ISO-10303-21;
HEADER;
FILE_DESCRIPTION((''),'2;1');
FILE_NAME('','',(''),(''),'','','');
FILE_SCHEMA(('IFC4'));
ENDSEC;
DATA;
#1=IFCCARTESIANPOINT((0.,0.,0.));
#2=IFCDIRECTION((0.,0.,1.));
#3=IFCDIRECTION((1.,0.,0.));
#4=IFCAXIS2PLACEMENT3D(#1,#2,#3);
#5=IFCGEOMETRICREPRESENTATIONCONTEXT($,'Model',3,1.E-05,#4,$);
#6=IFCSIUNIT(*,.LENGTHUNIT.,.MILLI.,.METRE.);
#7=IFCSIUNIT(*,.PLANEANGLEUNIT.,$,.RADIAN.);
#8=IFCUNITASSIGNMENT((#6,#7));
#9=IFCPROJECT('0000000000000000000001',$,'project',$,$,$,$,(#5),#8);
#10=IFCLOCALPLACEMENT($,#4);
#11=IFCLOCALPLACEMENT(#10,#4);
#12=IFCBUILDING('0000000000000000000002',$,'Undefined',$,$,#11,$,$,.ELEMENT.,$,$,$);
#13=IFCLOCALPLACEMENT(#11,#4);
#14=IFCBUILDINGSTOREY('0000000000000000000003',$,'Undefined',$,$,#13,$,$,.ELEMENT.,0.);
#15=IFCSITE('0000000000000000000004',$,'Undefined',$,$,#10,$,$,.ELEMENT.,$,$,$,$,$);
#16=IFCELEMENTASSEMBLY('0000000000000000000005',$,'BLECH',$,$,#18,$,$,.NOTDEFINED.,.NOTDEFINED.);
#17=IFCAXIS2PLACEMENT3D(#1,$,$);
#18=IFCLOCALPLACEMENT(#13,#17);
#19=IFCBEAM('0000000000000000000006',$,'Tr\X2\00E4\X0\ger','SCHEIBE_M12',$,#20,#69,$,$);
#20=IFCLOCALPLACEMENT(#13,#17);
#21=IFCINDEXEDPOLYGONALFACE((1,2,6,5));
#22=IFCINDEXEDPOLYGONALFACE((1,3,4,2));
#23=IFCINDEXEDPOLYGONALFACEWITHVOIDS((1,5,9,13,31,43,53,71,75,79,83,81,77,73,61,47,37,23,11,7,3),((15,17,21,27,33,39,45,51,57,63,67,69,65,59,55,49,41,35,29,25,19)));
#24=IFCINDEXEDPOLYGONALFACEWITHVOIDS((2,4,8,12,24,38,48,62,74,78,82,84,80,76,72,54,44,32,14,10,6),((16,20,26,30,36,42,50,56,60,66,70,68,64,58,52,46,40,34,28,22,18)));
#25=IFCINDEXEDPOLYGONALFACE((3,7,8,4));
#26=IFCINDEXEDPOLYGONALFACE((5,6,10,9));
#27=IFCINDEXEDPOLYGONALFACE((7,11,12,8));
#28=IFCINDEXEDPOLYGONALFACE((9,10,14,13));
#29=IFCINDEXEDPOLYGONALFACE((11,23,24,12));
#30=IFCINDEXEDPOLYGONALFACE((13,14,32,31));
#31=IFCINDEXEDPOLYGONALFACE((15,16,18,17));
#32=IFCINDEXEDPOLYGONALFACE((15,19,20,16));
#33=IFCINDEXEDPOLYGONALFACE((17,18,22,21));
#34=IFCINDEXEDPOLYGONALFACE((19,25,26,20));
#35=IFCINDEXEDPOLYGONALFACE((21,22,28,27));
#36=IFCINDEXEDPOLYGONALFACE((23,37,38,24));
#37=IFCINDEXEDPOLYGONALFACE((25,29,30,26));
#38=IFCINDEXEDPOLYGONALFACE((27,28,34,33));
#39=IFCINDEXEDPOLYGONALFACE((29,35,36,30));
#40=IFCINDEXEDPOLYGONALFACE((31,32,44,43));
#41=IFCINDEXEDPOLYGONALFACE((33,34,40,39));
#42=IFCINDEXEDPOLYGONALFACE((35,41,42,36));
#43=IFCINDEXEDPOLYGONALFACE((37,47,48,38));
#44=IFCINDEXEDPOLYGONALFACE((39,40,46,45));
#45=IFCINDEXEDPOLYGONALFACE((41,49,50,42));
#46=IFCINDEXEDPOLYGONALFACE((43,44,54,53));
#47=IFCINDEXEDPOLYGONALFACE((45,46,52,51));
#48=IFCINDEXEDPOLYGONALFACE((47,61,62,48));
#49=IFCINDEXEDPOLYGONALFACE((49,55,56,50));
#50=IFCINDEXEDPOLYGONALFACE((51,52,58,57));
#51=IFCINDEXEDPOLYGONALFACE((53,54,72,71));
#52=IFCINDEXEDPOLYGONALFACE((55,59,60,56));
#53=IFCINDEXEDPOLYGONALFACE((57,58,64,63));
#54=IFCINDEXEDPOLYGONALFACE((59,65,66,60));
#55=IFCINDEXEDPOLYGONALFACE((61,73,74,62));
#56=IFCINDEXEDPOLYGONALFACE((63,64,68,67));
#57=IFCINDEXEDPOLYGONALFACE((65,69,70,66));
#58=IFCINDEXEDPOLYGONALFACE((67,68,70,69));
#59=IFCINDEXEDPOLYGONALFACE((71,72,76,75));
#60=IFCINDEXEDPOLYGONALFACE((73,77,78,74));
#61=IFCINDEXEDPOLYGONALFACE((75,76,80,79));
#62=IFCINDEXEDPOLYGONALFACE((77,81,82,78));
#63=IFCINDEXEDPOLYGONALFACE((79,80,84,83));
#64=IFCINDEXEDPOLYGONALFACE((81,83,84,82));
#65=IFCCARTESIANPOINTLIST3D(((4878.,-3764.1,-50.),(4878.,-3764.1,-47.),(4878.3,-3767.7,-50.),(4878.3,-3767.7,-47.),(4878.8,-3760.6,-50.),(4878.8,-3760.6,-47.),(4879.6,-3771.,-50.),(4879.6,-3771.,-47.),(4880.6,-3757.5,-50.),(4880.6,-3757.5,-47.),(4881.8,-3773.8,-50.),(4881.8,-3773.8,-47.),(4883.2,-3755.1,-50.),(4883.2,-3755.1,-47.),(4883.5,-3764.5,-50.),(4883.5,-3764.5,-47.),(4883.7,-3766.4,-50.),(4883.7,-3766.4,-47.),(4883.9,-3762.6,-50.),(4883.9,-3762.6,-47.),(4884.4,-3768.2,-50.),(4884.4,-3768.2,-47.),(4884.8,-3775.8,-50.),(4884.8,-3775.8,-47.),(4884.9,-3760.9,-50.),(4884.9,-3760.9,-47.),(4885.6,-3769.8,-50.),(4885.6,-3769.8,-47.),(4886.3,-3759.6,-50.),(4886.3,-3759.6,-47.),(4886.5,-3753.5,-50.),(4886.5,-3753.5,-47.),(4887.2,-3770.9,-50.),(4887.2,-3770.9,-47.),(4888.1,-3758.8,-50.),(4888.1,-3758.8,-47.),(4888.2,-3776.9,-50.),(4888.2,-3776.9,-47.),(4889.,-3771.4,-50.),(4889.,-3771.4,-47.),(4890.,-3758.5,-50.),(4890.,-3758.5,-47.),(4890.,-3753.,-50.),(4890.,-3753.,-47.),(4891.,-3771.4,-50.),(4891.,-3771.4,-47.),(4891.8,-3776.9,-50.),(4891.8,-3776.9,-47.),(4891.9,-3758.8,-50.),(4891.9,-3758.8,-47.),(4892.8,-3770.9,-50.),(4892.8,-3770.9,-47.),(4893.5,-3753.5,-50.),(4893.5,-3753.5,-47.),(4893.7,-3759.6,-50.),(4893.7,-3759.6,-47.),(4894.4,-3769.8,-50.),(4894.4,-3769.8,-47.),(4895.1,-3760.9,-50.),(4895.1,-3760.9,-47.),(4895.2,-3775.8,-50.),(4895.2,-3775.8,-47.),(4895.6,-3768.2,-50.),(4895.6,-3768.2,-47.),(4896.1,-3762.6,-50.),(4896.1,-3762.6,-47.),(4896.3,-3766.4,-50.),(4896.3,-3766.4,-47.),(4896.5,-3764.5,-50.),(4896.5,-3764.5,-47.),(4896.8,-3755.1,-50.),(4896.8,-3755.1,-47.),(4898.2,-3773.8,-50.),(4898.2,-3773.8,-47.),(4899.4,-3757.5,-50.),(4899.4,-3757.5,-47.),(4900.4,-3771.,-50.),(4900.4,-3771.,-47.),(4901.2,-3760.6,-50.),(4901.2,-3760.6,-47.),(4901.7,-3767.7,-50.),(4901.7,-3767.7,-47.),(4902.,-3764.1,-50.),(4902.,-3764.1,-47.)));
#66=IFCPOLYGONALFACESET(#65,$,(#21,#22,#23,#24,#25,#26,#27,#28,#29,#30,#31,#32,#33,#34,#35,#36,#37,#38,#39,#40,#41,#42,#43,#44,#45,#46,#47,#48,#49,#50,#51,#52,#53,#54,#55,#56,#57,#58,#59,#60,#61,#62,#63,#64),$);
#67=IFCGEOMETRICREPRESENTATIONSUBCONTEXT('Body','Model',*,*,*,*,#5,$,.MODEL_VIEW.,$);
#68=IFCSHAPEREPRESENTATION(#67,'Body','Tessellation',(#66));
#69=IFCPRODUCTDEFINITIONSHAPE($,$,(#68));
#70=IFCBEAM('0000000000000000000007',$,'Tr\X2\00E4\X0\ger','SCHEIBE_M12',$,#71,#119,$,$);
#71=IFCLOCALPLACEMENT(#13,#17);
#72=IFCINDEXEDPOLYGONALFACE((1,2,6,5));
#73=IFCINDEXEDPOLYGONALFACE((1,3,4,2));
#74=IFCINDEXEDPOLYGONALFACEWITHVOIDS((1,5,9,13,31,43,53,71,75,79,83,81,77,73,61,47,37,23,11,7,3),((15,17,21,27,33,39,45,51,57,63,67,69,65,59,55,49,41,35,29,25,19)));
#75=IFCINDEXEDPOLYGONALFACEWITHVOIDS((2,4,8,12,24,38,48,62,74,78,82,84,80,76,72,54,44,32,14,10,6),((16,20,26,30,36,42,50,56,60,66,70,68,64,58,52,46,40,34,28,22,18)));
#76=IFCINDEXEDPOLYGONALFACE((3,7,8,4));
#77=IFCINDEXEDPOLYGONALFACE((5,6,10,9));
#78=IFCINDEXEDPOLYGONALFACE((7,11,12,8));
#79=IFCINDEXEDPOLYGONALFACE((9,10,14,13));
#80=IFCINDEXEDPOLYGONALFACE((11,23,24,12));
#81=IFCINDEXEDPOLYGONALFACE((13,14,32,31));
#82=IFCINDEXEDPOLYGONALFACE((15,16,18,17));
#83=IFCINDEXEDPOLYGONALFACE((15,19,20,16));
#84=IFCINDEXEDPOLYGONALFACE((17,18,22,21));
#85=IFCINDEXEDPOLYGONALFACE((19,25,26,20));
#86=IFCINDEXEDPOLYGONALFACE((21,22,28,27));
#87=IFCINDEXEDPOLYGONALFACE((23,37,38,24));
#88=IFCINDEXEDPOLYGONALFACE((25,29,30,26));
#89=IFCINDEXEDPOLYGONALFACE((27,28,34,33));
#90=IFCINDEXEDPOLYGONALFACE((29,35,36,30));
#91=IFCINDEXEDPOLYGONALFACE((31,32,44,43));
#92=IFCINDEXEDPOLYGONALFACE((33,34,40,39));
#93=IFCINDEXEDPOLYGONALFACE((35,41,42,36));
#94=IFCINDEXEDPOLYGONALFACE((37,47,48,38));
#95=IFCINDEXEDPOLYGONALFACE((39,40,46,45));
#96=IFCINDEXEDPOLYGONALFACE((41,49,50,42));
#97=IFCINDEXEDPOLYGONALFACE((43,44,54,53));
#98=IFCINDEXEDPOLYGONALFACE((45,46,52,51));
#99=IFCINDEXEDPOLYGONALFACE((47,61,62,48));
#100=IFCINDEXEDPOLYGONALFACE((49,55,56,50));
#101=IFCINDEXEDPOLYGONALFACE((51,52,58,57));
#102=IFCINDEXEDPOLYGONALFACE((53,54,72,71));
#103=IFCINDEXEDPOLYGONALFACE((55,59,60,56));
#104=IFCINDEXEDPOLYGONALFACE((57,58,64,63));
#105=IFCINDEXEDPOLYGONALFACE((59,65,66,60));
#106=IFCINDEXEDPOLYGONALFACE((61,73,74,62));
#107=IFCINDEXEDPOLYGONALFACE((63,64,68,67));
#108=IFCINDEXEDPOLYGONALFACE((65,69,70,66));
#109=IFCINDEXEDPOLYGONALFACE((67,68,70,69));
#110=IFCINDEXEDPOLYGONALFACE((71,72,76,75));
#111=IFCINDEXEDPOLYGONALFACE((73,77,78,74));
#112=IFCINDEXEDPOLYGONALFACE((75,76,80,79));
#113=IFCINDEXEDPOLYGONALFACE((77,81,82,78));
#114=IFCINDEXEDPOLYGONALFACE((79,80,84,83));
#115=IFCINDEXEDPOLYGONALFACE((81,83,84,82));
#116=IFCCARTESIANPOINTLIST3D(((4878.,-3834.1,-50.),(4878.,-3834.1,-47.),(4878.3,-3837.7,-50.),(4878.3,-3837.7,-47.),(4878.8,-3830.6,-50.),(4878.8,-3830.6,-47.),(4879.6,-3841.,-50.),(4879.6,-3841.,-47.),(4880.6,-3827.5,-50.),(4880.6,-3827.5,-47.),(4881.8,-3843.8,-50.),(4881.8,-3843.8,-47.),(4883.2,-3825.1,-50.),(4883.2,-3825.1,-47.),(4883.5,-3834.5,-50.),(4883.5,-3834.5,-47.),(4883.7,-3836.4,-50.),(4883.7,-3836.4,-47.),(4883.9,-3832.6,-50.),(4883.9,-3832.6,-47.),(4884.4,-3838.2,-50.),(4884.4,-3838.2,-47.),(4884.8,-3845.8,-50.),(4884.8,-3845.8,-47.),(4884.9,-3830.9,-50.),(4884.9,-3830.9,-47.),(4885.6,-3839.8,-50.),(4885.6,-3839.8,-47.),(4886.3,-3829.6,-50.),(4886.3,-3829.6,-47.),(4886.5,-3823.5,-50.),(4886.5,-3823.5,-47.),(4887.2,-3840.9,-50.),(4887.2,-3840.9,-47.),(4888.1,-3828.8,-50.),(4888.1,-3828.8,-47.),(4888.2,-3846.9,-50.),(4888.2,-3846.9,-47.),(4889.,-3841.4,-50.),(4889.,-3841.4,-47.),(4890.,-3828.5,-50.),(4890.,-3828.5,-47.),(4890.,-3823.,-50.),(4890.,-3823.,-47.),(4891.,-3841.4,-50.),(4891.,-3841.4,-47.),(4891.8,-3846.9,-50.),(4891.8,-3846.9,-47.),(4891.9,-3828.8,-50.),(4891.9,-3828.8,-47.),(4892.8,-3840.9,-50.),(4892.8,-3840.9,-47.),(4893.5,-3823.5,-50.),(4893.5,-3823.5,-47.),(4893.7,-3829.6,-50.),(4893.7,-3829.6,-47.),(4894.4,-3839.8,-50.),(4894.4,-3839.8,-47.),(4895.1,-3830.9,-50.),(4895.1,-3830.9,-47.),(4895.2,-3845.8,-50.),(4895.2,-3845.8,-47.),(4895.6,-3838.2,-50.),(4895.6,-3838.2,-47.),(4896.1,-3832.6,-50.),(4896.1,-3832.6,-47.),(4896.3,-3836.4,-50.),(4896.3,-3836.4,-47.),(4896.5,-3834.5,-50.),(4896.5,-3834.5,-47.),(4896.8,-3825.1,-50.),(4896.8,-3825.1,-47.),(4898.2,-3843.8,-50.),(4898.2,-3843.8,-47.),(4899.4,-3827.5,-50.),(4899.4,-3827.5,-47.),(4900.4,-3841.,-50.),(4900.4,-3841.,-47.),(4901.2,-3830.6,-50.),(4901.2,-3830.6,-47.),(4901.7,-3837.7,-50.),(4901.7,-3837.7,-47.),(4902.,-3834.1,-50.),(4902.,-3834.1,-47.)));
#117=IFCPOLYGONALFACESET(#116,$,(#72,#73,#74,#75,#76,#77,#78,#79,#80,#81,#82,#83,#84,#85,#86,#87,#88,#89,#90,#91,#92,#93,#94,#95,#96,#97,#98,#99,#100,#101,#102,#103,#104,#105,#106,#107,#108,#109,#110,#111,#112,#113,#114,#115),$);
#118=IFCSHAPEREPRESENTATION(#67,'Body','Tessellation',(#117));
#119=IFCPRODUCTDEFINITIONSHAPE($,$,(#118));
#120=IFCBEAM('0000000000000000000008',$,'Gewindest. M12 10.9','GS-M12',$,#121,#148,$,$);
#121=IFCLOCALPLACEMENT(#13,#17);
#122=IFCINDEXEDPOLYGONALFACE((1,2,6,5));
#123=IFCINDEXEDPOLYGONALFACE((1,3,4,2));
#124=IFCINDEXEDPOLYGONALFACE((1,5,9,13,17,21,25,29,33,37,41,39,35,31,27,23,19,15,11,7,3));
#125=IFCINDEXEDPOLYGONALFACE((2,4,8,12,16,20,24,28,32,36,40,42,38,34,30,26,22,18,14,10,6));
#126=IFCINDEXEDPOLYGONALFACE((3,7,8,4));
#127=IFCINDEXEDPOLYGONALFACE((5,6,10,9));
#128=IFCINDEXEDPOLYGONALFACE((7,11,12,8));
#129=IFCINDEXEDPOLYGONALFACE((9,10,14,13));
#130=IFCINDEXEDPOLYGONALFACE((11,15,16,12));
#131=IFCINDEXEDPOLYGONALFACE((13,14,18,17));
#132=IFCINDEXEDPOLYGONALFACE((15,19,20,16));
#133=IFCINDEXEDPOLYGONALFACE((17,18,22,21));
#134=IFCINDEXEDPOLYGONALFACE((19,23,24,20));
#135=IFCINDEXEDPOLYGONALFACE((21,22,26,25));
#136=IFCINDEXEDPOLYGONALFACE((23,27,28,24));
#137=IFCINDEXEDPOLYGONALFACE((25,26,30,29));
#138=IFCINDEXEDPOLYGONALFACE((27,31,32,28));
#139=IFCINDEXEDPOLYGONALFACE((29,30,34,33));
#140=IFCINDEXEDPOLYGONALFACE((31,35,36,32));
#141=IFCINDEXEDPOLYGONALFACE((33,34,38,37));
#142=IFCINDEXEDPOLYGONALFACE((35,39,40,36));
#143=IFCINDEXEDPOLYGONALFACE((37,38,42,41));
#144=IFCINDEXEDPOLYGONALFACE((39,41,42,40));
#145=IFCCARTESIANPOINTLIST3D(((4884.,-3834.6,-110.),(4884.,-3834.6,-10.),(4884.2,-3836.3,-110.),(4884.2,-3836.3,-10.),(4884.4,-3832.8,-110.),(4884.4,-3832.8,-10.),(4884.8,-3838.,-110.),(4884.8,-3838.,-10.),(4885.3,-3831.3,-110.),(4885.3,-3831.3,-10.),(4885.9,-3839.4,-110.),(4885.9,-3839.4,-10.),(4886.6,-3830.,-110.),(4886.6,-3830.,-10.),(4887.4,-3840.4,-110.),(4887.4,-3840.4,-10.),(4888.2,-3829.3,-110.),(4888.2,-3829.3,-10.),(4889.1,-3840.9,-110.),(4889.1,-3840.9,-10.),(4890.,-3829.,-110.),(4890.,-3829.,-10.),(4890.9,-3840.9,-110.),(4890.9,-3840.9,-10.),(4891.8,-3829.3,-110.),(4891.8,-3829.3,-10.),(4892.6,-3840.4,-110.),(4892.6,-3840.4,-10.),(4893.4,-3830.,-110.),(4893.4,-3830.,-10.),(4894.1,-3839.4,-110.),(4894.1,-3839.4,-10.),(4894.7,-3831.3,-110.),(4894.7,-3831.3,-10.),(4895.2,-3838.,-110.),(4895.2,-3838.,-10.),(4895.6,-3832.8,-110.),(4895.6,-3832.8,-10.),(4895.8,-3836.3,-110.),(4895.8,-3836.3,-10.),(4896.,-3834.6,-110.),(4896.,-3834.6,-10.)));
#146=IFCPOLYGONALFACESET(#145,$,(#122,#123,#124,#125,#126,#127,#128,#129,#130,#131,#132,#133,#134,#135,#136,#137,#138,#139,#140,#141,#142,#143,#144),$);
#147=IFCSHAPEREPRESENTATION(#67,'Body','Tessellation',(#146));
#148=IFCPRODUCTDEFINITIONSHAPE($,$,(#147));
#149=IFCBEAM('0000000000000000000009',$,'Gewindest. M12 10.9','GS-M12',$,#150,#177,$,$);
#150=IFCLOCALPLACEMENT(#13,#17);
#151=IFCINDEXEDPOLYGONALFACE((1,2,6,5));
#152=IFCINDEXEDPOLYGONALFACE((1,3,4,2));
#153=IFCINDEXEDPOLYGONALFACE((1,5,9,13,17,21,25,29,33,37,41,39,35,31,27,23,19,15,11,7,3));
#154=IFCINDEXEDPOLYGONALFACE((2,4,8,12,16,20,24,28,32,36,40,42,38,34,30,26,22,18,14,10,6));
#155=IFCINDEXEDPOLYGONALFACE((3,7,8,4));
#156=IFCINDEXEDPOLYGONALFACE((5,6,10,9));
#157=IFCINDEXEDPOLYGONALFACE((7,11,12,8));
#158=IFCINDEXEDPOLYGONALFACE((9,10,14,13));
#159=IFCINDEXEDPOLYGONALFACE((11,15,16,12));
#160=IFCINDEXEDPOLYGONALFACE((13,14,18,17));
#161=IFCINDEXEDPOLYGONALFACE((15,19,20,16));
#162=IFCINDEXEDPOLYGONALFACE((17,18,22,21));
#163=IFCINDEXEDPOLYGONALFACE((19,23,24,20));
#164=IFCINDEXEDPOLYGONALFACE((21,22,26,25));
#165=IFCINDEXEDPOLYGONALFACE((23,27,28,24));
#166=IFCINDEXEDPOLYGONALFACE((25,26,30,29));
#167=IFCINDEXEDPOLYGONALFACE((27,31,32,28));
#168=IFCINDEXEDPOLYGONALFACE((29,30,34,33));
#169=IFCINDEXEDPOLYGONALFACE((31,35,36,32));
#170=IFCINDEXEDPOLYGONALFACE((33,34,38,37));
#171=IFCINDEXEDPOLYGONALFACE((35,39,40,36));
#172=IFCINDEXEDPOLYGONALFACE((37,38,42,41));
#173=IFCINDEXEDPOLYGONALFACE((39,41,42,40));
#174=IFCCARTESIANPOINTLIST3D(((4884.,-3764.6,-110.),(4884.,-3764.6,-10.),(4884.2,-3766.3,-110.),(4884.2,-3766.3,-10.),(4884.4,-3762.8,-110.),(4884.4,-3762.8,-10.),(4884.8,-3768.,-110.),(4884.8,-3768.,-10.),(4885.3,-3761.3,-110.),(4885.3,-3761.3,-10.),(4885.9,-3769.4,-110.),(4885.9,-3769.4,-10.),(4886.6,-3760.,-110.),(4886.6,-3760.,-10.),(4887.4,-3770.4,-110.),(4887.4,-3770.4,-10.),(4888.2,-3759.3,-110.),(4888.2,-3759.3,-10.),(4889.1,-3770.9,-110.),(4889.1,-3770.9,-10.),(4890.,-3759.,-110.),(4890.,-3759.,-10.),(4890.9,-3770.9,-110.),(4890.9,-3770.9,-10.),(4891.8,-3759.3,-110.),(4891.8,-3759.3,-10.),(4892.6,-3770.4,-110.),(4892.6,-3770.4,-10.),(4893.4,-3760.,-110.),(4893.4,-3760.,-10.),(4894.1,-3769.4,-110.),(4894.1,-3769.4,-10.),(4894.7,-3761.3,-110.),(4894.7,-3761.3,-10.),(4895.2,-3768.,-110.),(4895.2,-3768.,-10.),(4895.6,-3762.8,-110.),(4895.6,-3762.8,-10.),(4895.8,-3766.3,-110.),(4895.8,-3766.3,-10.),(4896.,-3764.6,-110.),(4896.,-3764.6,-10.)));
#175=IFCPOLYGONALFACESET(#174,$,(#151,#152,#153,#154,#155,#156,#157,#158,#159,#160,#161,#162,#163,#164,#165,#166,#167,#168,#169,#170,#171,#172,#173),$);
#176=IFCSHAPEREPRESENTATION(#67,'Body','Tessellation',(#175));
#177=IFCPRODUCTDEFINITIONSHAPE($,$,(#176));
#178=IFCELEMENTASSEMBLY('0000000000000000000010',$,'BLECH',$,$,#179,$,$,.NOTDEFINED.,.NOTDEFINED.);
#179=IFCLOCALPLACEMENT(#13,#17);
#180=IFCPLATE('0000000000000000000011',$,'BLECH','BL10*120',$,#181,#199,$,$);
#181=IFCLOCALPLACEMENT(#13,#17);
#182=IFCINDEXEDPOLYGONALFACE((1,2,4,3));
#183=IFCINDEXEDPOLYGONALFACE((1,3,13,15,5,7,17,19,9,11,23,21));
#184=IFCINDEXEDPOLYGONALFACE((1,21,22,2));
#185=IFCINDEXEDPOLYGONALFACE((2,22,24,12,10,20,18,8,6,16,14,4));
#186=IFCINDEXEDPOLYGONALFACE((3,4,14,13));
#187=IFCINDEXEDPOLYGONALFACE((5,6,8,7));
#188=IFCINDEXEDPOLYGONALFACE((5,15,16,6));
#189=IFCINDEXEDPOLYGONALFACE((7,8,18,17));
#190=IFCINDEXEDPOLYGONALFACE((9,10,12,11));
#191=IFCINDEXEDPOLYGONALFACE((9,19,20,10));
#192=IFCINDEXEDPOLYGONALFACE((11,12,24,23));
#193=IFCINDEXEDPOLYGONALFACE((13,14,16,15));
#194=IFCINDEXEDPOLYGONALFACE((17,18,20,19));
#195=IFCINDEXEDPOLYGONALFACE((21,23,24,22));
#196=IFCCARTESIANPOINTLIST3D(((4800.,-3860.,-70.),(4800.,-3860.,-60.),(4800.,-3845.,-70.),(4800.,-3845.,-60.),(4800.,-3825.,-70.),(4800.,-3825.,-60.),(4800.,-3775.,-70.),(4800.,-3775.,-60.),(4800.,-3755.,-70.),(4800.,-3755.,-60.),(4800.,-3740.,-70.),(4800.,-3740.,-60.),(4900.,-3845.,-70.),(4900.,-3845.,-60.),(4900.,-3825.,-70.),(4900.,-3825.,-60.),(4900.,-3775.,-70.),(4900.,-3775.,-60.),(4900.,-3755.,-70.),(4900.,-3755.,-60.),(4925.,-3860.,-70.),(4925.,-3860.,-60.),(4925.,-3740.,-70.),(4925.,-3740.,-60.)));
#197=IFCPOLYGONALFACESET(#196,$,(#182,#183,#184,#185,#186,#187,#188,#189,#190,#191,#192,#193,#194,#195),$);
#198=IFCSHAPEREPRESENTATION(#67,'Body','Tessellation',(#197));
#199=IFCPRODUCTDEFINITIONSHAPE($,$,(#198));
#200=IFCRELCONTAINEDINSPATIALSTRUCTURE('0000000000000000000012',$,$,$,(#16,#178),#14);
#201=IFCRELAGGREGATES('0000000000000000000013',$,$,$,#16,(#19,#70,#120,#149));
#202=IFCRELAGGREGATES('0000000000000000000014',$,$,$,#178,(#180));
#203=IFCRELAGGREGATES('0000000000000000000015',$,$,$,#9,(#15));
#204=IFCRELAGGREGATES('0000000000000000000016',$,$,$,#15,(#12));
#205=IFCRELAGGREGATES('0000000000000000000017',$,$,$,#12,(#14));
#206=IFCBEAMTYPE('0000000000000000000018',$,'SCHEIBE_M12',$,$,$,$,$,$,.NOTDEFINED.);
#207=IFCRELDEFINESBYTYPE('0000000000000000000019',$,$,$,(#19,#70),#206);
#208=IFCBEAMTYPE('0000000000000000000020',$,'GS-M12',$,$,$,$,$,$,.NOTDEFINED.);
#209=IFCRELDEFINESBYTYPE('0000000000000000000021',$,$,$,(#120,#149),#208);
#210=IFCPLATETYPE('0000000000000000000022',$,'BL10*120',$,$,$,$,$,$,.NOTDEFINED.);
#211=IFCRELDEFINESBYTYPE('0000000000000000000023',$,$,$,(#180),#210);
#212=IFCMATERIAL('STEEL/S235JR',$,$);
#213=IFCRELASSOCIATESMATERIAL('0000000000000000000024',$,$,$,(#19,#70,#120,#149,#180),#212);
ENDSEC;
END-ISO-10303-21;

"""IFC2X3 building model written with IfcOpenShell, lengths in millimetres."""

from ifc_helpers import new_model, si_unit, frame, origin_with_axes, origin_2d_with_axis, place, context, subcontext, project, spatial, polyline, circle, hollow_circle, outline, extrude, material, type_object, element, aggregate, save


model = new_model("IFC2X3")

# Units and contexts
model_context = context("Model", 3, precision=1e-05, world=origin_with_axes())
body_context = subcontext(model_context, "Body", "Model", "MODEL_VIEW")
ifc_project = project(units=[si_unit("LENGTHUNIT", "METRE", prefix="MILLI"), si_unit("PLANEANGLEUNIT", "RADIAN")], contexts=[model_context])

# Site, building, storey
site_placement = place(None, origin_with_axes())
site = spatial("IfcSite", under=ifc_project, at=site_placement, Name="Undefined", CompositionType="ELEMENT")
building_placement = place(site_placement, origin_with_axes())
building = spatial("IfcBuilding", under=site, at=building_placement, Name="Undefined", CompositionType="ELEMENT")
storey_placement = place(building_placement, origin_with_axes())
storey = spatial("IfcBuildingStorey", under=building, at=storey_placement, Name="Undefined", CompositionType="ELEMENT", Elevation=0.0)

# Shared definitions
ifc_material_1 = material(Name="STEEL/S235JR")

# Element assembly, beams
assembly_1_placement = place(storey_placement, origin_with_axes())
assembly_1 = element("IfcElementAssembly", 1, at=assembly_1_placement, inside=storey, Name="BLECH", AssemblyPlace="NOTDEFINED", PredefinedType="NOTDEFINED")
beam_type_1 = type_object("IfcBeamType", Name="SCHEIBE_M12", PredefinedType="NOTDEFINED")
beam_1_placement = place(assembly_1_placement, frame((4890.0, -3765.0, -47.0), z_axis=(-1.0, 0.0, 0.0), x_axis=(0.0, 0.0, -1.0)))
beam_1 = element("IfcBeam", 2, at=beam_1_placement, type_object=beam_type_1, material=ifc_material_1, Name="Träger", Description="SCHEIBE_M12", context=body_context, shape_type="SweptSolid", body=[
    extrude(hollow_circle(Radius=12.0, WallThickness=5.5, at=origin_2d_with_axis()), frame((3.0, 0.0, 0.0), z_axis=(-1.0, 0.0, 0.0), x_axis=(0.0, -1.0, 0.0)), (0.0, 0.0, 1.0), 3.0),
])
beam_2_placement = place(assembly_1_placement, frame((4890.0, -3835.0, -47.0), z_axis=(-1.0, 0.0, 0.0), x_axis=(0.0, 0.0, -1.0)))
beam_2 = element("IfcBeam", 3, at=beam_2_placement, type_object=beam_type_1, material=ifc_material_1, Name="Träger", Description="SCHEIBE_M12", context=body_context, shape_type="SweptSolid", body=[
    extrude(hollow_circle(Radius=12.0, WallThickness=5.5, at=origin_2d_with_axis()), frame((3.0, 0.0, 0.0), z_axis=(-1.0, 0.0, 0.0), x_axis=(0.0, -1.0, 0.0)), (0.0, 0.0, 1.0), 3.0),
])
beam_type_2 = type_object("IfcBeamType", Name="GS-M12", PredefinedType="NOTDEFINED")
beam_3_placement = place(assembly_1_placement, frame((4890.0, -3835.0, -10.0), z_axis=(-1.0, 0.0, 0.0), x_axis=(0.0, 0.0, -1.0)))
beam_3 = element("IfcBeam", 4, at=beam_3_placement, type_object=beam_type_2, material=ifc_material_1, Name="Gewindest. M12 10.9", Description="GS-M12", context=body_context, shape_type="SweptSolid", body=[
    extrude(circle(Radius=6.0, at=origin_2d_with_axis()), frame((100.0, 0.0, 0.0), z_axis=(-1.0, 0.0, 0.0), x_axis=(0.0, -1.0, 0.0)), (0.0, 0.0, 1.0), 100.0),
])
beam_4_placement = place(assembly_1_placement, frame((4890.0, -3765.0, -10.0), z_axis=(-1.0, 0.0, 0.0), x_axis=(0.0, 0.0, -1.0)))
beam_4 = element("IfcBeam", 5, at=beam_4_placement, type_object=beam_type_2, material=ifc_material_1, Name="Gewindest. M12 10.9", Description="GS-M12", context=body_context, shape_type="SweptSolid", body=[
    extrude(circle(Radius=6.0, at=origin_2d_with_axis()), frame((100.0, 0.0, 0.0), z_axis=(-1.0, 0.0, 0.0), x_axis=(0.0, -1.0, 0.0)), (0.0, 0.0, 1.0), 100.0),
])
aggregate(assembly_1, [beam_1, beam_2, beam_3, beam_4])

# Element assembly, plate
assembly_2_placement = place(storey_placement, origin_with_axes())
assembly_2 = element("IfcElementAssembly", 6, at=assembly_2_placement, inside=storey, Name="BLECH", AssemblyPlace="NOTDEFINED", PredefinedType="NOTDEFINED")
plate_type_1 = type_object("IfcPlateType", Name="BL10*120", PredefinedType="NOTDEFINED")
plate_1_placement = place(assembly_2_placement, frame((4925.0, -3740.0, -65.0), z_axis=(0.0, 0.0, 1.0), x_axis=(-1.0, 0.0, 0.0)))
plate_1 = element("IfcPlate", 7, at=plate_1_placement, type_object=plate_type_1, material=ifc_material_1, Name="BLECH", Description="BL10*120", context=body_context, shape_type="SweptSolid", body=[
    extrude(outline(polyline([(0.0, 0.0), (125.0, 0.0), (125.0, 15.0), (25.0, 15.0), (25.0, 35.0), (125.0, 35.0), (125.0, 85.0), (25.0, 85.0), (25.0, 105.0), (125.0, 105.0), (125.0, 120.0), (0.0, 120.0), (0.0, 0.0)])), frame((0.0, 0.0, -5.0), z_axis=(0.0, 0.0, 1.0), x_axis=(1.0, 0.0, 0.0)), (0.0, 0.0, 1.0), 10.0),
])
aggregate(assembly_2, [plate_1])

save(model, "model.ifc")
